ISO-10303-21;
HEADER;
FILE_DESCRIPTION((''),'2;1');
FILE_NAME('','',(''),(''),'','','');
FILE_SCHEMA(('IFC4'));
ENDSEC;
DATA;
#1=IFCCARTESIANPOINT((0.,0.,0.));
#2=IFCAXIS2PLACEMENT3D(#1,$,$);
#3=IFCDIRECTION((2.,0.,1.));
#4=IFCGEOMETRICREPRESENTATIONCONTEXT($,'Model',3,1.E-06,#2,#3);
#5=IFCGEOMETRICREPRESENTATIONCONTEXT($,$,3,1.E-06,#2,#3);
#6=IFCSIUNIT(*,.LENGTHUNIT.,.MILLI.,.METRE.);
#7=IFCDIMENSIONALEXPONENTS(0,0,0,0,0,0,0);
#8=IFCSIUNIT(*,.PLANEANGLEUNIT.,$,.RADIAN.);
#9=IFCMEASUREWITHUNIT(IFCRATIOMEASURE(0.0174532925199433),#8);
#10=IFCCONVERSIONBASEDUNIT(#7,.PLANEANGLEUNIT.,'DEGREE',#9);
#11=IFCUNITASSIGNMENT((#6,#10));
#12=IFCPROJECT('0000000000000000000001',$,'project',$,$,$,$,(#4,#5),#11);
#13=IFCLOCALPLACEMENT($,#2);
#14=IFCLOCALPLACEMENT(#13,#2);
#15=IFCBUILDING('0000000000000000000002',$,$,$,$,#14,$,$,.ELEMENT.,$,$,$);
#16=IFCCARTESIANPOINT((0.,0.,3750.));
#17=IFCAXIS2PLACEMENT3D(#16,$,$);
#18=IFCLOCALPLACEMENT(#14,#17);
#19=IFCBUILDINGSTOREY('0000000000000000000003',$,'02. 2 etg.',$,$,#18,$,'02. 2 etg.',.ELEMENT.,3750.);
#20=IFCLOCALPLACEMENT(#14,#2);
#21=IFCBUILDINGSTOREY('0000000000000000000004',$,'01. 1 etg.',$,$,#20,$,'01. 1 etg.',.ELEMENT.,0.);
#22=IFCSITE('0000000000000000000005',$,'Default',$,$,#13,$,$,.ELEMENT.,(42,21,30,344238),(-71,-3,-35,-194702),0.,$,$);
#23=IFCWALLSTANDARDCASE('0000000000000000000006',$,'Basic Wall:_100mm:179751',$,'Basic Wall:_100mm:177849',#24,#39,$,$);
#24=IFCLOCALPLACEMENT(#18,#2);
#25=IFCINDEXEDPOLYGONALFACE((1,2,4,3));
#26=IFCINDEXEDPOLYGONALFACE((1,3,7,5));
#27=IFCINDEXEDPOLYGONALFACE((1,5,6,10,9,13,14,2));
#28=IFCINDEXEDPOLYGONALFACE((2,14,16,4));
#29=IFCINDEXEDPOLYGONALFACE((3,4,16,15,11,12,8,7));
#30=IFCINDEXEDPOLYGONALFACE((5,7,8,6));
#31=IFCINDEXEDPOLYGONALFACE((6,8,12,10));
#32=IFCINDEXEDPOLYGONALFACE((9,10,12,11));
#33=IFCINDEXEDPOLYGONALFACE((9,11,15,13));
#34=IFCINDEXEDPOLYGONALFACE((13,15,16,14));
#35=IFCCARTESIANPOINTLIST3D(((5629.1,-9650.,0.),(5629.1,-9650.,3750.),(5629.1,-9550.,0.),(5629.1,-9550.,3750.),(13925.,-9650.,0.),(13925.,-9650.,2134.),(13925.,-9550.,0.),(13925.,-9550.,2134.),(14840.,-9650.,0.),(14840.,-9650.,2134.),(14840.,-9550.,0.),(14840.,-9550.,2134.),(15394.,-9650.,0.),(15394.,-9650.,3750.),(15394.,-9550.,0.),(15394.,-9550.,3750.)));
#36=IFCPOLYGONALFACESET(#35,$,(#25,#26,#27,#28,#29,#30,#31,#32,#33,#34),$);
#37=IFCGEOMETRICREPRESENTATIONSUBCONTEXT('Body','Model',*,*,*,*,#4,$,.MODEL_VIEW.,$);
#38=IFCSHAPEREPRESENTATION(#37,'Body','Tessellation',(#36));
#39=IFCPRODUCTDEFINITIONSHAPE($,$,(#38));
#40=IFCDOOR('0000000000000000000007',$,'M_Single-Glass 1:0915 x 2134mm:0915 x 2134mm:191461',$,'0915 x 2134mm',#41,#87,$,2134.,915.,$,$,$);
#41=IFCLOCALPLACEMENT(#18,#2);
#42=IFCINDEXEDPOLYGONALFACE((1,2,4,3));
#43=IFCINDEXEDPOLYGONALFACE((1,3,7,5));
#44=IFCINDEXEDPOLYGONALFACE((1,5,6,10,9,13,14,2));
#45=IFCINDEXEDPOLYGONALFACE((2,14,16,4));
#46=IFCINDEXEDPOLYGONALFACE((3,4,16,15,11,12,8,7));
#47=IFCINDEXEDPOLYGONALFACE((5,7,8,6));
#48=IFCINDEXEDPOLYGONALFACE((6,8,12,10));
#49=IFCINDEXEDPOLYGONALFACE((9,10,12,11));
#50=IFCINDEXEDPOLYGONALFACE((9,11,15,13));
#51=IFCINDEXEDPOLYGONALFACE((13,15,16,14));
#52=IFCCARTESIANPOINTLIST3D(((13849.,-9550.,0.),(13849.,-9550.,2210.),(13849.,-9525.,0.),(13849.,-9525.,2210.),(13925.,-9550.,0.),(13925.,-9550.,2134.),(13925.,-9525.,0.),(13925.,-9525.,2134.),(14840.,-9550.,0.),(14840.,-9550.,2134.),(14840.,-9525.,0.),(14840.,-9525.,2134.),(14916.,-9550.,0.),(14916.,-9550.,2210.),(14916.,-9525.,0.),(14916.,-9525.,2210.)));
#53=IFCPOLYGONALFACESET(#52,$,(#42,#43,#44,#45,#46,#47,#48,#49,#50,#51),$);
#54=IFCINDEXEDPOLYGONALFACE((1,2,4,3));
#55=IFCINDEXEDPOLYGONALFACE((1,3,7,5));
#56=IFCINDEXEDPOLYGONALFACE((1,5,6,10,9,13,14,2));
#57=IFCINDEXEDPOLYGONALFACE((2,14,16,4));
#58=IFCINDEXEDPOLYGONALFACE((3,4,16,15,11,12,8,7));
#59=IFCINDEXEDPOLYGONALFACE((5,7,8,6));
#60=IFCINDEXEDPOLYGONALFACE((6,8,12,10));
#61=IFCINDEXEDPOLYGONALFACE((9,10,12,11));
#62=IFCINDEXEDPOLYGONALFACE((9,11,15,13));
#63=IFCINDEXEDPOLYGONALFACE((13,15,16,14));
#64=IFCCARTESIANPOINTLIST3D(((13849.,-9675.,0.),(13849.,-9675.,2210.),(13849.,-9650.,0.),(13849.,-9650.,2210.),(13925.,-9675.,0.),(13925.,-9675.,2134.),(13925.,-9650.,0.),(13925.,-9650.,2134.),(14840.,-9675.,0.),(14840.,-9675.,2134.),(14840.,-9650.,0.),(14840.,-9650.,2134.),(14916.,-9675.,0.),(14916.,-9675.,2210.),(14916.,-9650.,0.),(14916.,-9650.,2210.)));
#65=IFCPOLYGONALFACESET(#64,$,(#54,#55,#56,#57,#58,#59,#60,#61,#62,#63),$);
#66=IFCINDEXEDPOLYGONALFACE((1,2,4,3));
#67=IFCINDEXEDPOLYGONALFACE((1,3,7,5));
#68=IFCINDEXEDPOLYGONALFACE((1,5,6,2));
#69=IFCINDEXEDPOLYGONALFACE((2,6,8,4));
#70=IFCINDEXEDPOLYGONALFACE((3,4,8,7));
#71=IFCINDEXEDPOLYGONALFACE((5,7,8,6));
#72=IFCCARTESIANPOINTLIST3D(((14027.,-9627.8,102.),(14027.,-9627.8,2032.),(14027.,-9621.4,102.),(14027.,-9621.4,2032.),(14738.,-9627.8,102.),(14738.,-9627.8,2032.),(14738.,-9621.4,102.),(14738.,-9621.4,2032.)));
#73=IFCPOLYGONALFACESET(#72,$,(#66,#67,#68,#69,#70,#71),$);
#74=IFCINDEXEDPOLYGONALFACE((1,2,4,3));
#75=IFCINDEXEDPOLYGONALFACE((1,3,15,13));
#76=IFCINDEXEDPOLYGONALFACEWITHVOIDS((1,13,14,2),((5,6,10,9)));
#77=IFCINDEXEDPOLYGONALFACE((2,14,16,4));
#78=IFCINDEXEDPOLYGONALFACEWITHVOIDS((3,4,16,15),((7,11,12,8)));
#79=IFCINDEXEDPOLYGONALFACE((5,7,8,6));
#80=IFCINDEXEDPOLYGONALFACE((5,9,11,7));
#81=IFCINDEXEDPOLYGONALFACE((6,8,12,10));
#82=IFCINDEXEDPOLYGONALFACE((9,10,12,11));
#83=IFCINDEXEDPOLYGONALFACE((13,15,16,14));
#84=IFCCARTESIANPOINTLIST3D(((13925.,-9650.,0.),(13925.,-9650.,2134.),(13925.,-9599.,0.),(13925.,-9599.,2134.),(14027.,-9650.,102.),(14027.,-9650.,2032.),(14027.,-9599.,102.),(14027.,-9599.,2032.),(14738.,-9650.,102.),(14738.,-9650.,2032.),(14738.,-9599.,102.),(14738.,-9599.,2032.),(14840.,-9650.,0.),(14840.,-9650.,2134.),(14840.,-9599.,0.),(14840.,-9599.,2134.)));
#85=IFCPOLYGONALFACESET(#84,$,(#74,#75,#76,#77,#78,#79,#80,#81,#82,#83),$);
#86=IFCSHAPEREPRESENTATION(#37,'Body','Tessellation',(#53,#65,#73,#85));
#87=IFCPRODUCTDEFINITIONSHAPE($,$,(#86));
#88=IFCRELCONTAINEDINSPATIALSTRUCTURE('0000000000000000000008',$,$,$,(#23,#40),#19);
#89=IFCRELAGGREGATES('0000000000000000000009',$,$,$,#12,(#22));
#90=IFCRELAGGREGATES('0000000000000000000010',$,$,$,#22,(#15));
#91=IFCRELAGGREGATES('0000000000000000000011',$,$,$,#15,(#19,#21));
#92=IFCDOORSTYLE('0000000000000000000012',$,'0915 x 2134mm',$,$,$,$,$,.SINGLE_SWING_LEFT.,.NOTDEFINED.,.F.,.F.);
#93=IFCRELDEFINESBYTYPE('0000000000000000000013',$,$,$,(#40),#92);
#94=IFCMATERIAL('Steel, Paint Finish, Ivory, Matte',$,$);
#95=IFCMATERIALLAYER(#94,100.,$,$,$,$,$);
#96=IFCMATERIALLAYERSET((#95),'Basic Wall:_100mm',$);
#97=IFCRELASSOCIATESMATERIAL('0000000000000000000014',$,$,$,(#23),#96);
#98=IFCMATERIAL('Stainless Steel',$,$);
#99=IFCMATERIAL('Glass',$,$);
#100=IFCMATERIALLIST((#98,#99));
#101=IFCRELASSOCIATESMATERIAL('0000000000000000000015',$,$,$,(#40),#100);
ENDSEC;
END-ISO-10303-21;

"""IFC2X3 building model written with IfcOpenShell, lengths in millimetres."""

from ifc_helpers import new_model, entity, si_unit, converted_unit, direction, frame, frame_2d, origin, origin_2d_with_axis, place, context, subcontext, project, spatial, polyline, rectangle, outline, extrude, source, transform, mapped, material, material_list, layer, layer_set, layer_usage, type_object, type_shapes, element, fill, save


model = new_model("IFC2X3")

# Units and contexts
model_context = context("Model", 3, precision=1e-06, world=origin(), true_north=direction((2.0, 0.0, 1.0)))
context_of_model = context(None, 3, precision=1e-06, world=origin(), true_north=direction((2.0, 0.0, 1.0)))
body_context = subcontext(model_context, "Body", "Model", "MODEL_VIEW")
ifc_project = project(units=[si_unit("LENGTHUNIT", "METRE", prefix="MILLI"), converted_unit("PLANEANGLEUNIT", "DEGREE", entity("IfcRatioMeasure", 0.0174532925199433), si_unit("PLANEANGLEUNIT", "RADIAN"), dimensions=[0, 0, 0, 0, 0, 0, 0])], contexts=[model_context, context_of_model])

# Site, building, storey
site_placement = place(None, origin())
site = spatial("IfcSite", under=ifc_project, at=site_placement, Name="Default", CompositionType="ELEMENT", RefLatitude=(42, 21, 30, 344238), RefLongitude=(-71, -3, -35, -194702), RefElevation=0.0)
building_placement = place(site_placement, origin())
building = spatial("IfcBuilding", under=site, at=building_placement, CompositionType="ELEMENT")
storey_1_placement = place(building_placement, frame((0.0, 0.0, 3750.0)))
storey_1 = spatial("IfcBuildingStorey", under=building, at=storey_1_placement, Name="02. 2 etg.", LongName="02. 2 etg.", CompositionType="ELEMENT", Elevation=3750.0)

# Wall, opening, door
ifc_material_1 = material(Name="Steel, Paint Finish, Ivory, Matte")
ifc_layer_1 = layer(ifc_material_1, 100.0)
ifc_layer_set_1 = layer_set([ifc_layer_1], Name="Basic Wall:_100mm")
ifc_layer_usage_1 = layer_usage(ifc_layer_set_1, "AXIS2", "NEGATIVE", 50.0)
wall_1_placement = place(storey_1_placement, frame((15394.0, -9600.0, 0.0), z_axis=(0.0, 0.0, 1.0), x_axis=(-1.0, 0.0, 0.0)))
wall_1 = element("IfcWallStandardCase", 1, at=wall_1_placement, inside=storey_1, material=ifc_layer_usage_1, Name="Basic Wall:_100mm:179751", ObjectType="Basic Wall:_100mm:177849", context=body_context, shape_type="SweptSolid", body=[
    extrude(rectangle(XDim=9764.9, YDim=100.0, at=frame_2d((4882.4, 0.0), x_axis=(-1.0, 0.0))), origin(), (0.0, 0.0, 1.0), 3750.0),
])
opening_1_placement = place(wall_1_placement, frame((554.0, -50.0, 0.0)))
opening_1 = element("IfcOpeningElement", 2, at=opening_1_placement, cuts=wall_1, ObjectType="Opening", context=body_context, shape_type="SweptSolid", body=[
    extrude(rectangle(XDim=915.0, YDim=2134.0, at=frame_2d((1067.0, 457.5), x_axis=(0.0, -1.0))), frame((0.0, 0.0, 0.0), z_axis=(0.0, 1.0, 0.0), x_axis=(0.0, 0.0, 1.0)), (0.0, 0.0, 1.0), 100.0),
])
ifc_material_2 = material(Name="Stainless Steel")
ifc_material_3 = material(Name="Glass")
ifc_material_list_1 = material_list([ifc_material_2, ifc_material_3])
door_style_1 = type_object("IfcDoorStyle", Name="0915 x 2134mm", ConstructionType="NOTDEFINED", OperationType="SINGLE_SWING_LEFT", ParameterTakesPrecedence=False, Sizeable=False)
shared_shape_1 = source(origin(), body_context, "Body", "SweptSolid", [
    extrude(outline(polyline([(-457.5, -1048.0), (-457.5, 1086.0), (-533.5, 1086.0), (-533.5, -1124.0), (533.5, -1124.0), (533.5, 1086.0), (457.5, 1086.0), (457.5, -1048.0), (-457.5, -1048.0)])), frame((457.5, 0.0, 1086.0), z_axis=(0.0, 1.0, 0.0), x_axis=(1.0, 0.0, 0.0)), (0.0, 0.0, -1.0), 25.0),
    extrude(outline(polyline([(-457.5, -1048.0), (-457.5, 1086.0), (-533.5, 1086.0), (-533.5, -1124.0), (533.5, -1124.0), (533.5, 1086.0), (457.5, 1086.0), (457.5, -1048.0), (-457.5, -1048.0)])), frame((457.5, 125.0, 1086.0), z_axis=(0.0, 1.0, 0.0), x_axis=(1.0, 0.0, 0.0)), (0.0, 0.0, -1.0), 25.0),
    extrude(rectangle(XDim=711.0, YDim=6.3, at=origin_2d_with_axis()), frame((457.5, 74.6, 102.0)), (0.0, 0.0, 1.0), 1930.0),
    extrude(outline(polyline([(-1067.0, -457.5), (1067.0, -457.5), (1067.0, 457.5), (-1067.0, 457.5), (-1067.0, -457.5)]), holes=[polyline([(-965.0, 355.5), (965.0, 355.5), (965.0, -355.5), (-965.0, -355.5), (-965.0, 355.5)])]), frame((457.5, 100.0, 1067.0), z_axis=(0.0, -1.0, 0.0), x_axis=(0.0, 0.0, -1.0)), (0.0, 0.0, 1.0), 51.0),
])
type_shapes(door_style_1, [shared_shape_1])
door_1_placement = place(opening_1_placement, origin())
door_1 = element("IfcDoor", 3, at=door_1_placement, inside=storey_1, type_object=door_style_1, material=ifc_material_list_1, Name="M_Single-Glass 1:0915 x 2134mm:0915 x 2134mm:191461", ObjectType="0915 x 2134mm", OverallHeight=2134.0, OverallWidth=915.0, context=body_context, shape_type="MappedRepresentation", body=[
    mapped(shared_shape_1, transform((0.0, 0.0, 0.0), scale=1.0)),
])
fill(opening_1, door_1)

# Shared definitions
storey_2_placement = place(building_placement, origin())
storey_2 = spatial("IfcBuildingStorey", under=building, at=storey_2_placement, Name="01. 1 etg.", LongName="01. 1 etg.", CompositionType="ELEMENT", Elevation=0.0)

save(model, "model.ifc")
